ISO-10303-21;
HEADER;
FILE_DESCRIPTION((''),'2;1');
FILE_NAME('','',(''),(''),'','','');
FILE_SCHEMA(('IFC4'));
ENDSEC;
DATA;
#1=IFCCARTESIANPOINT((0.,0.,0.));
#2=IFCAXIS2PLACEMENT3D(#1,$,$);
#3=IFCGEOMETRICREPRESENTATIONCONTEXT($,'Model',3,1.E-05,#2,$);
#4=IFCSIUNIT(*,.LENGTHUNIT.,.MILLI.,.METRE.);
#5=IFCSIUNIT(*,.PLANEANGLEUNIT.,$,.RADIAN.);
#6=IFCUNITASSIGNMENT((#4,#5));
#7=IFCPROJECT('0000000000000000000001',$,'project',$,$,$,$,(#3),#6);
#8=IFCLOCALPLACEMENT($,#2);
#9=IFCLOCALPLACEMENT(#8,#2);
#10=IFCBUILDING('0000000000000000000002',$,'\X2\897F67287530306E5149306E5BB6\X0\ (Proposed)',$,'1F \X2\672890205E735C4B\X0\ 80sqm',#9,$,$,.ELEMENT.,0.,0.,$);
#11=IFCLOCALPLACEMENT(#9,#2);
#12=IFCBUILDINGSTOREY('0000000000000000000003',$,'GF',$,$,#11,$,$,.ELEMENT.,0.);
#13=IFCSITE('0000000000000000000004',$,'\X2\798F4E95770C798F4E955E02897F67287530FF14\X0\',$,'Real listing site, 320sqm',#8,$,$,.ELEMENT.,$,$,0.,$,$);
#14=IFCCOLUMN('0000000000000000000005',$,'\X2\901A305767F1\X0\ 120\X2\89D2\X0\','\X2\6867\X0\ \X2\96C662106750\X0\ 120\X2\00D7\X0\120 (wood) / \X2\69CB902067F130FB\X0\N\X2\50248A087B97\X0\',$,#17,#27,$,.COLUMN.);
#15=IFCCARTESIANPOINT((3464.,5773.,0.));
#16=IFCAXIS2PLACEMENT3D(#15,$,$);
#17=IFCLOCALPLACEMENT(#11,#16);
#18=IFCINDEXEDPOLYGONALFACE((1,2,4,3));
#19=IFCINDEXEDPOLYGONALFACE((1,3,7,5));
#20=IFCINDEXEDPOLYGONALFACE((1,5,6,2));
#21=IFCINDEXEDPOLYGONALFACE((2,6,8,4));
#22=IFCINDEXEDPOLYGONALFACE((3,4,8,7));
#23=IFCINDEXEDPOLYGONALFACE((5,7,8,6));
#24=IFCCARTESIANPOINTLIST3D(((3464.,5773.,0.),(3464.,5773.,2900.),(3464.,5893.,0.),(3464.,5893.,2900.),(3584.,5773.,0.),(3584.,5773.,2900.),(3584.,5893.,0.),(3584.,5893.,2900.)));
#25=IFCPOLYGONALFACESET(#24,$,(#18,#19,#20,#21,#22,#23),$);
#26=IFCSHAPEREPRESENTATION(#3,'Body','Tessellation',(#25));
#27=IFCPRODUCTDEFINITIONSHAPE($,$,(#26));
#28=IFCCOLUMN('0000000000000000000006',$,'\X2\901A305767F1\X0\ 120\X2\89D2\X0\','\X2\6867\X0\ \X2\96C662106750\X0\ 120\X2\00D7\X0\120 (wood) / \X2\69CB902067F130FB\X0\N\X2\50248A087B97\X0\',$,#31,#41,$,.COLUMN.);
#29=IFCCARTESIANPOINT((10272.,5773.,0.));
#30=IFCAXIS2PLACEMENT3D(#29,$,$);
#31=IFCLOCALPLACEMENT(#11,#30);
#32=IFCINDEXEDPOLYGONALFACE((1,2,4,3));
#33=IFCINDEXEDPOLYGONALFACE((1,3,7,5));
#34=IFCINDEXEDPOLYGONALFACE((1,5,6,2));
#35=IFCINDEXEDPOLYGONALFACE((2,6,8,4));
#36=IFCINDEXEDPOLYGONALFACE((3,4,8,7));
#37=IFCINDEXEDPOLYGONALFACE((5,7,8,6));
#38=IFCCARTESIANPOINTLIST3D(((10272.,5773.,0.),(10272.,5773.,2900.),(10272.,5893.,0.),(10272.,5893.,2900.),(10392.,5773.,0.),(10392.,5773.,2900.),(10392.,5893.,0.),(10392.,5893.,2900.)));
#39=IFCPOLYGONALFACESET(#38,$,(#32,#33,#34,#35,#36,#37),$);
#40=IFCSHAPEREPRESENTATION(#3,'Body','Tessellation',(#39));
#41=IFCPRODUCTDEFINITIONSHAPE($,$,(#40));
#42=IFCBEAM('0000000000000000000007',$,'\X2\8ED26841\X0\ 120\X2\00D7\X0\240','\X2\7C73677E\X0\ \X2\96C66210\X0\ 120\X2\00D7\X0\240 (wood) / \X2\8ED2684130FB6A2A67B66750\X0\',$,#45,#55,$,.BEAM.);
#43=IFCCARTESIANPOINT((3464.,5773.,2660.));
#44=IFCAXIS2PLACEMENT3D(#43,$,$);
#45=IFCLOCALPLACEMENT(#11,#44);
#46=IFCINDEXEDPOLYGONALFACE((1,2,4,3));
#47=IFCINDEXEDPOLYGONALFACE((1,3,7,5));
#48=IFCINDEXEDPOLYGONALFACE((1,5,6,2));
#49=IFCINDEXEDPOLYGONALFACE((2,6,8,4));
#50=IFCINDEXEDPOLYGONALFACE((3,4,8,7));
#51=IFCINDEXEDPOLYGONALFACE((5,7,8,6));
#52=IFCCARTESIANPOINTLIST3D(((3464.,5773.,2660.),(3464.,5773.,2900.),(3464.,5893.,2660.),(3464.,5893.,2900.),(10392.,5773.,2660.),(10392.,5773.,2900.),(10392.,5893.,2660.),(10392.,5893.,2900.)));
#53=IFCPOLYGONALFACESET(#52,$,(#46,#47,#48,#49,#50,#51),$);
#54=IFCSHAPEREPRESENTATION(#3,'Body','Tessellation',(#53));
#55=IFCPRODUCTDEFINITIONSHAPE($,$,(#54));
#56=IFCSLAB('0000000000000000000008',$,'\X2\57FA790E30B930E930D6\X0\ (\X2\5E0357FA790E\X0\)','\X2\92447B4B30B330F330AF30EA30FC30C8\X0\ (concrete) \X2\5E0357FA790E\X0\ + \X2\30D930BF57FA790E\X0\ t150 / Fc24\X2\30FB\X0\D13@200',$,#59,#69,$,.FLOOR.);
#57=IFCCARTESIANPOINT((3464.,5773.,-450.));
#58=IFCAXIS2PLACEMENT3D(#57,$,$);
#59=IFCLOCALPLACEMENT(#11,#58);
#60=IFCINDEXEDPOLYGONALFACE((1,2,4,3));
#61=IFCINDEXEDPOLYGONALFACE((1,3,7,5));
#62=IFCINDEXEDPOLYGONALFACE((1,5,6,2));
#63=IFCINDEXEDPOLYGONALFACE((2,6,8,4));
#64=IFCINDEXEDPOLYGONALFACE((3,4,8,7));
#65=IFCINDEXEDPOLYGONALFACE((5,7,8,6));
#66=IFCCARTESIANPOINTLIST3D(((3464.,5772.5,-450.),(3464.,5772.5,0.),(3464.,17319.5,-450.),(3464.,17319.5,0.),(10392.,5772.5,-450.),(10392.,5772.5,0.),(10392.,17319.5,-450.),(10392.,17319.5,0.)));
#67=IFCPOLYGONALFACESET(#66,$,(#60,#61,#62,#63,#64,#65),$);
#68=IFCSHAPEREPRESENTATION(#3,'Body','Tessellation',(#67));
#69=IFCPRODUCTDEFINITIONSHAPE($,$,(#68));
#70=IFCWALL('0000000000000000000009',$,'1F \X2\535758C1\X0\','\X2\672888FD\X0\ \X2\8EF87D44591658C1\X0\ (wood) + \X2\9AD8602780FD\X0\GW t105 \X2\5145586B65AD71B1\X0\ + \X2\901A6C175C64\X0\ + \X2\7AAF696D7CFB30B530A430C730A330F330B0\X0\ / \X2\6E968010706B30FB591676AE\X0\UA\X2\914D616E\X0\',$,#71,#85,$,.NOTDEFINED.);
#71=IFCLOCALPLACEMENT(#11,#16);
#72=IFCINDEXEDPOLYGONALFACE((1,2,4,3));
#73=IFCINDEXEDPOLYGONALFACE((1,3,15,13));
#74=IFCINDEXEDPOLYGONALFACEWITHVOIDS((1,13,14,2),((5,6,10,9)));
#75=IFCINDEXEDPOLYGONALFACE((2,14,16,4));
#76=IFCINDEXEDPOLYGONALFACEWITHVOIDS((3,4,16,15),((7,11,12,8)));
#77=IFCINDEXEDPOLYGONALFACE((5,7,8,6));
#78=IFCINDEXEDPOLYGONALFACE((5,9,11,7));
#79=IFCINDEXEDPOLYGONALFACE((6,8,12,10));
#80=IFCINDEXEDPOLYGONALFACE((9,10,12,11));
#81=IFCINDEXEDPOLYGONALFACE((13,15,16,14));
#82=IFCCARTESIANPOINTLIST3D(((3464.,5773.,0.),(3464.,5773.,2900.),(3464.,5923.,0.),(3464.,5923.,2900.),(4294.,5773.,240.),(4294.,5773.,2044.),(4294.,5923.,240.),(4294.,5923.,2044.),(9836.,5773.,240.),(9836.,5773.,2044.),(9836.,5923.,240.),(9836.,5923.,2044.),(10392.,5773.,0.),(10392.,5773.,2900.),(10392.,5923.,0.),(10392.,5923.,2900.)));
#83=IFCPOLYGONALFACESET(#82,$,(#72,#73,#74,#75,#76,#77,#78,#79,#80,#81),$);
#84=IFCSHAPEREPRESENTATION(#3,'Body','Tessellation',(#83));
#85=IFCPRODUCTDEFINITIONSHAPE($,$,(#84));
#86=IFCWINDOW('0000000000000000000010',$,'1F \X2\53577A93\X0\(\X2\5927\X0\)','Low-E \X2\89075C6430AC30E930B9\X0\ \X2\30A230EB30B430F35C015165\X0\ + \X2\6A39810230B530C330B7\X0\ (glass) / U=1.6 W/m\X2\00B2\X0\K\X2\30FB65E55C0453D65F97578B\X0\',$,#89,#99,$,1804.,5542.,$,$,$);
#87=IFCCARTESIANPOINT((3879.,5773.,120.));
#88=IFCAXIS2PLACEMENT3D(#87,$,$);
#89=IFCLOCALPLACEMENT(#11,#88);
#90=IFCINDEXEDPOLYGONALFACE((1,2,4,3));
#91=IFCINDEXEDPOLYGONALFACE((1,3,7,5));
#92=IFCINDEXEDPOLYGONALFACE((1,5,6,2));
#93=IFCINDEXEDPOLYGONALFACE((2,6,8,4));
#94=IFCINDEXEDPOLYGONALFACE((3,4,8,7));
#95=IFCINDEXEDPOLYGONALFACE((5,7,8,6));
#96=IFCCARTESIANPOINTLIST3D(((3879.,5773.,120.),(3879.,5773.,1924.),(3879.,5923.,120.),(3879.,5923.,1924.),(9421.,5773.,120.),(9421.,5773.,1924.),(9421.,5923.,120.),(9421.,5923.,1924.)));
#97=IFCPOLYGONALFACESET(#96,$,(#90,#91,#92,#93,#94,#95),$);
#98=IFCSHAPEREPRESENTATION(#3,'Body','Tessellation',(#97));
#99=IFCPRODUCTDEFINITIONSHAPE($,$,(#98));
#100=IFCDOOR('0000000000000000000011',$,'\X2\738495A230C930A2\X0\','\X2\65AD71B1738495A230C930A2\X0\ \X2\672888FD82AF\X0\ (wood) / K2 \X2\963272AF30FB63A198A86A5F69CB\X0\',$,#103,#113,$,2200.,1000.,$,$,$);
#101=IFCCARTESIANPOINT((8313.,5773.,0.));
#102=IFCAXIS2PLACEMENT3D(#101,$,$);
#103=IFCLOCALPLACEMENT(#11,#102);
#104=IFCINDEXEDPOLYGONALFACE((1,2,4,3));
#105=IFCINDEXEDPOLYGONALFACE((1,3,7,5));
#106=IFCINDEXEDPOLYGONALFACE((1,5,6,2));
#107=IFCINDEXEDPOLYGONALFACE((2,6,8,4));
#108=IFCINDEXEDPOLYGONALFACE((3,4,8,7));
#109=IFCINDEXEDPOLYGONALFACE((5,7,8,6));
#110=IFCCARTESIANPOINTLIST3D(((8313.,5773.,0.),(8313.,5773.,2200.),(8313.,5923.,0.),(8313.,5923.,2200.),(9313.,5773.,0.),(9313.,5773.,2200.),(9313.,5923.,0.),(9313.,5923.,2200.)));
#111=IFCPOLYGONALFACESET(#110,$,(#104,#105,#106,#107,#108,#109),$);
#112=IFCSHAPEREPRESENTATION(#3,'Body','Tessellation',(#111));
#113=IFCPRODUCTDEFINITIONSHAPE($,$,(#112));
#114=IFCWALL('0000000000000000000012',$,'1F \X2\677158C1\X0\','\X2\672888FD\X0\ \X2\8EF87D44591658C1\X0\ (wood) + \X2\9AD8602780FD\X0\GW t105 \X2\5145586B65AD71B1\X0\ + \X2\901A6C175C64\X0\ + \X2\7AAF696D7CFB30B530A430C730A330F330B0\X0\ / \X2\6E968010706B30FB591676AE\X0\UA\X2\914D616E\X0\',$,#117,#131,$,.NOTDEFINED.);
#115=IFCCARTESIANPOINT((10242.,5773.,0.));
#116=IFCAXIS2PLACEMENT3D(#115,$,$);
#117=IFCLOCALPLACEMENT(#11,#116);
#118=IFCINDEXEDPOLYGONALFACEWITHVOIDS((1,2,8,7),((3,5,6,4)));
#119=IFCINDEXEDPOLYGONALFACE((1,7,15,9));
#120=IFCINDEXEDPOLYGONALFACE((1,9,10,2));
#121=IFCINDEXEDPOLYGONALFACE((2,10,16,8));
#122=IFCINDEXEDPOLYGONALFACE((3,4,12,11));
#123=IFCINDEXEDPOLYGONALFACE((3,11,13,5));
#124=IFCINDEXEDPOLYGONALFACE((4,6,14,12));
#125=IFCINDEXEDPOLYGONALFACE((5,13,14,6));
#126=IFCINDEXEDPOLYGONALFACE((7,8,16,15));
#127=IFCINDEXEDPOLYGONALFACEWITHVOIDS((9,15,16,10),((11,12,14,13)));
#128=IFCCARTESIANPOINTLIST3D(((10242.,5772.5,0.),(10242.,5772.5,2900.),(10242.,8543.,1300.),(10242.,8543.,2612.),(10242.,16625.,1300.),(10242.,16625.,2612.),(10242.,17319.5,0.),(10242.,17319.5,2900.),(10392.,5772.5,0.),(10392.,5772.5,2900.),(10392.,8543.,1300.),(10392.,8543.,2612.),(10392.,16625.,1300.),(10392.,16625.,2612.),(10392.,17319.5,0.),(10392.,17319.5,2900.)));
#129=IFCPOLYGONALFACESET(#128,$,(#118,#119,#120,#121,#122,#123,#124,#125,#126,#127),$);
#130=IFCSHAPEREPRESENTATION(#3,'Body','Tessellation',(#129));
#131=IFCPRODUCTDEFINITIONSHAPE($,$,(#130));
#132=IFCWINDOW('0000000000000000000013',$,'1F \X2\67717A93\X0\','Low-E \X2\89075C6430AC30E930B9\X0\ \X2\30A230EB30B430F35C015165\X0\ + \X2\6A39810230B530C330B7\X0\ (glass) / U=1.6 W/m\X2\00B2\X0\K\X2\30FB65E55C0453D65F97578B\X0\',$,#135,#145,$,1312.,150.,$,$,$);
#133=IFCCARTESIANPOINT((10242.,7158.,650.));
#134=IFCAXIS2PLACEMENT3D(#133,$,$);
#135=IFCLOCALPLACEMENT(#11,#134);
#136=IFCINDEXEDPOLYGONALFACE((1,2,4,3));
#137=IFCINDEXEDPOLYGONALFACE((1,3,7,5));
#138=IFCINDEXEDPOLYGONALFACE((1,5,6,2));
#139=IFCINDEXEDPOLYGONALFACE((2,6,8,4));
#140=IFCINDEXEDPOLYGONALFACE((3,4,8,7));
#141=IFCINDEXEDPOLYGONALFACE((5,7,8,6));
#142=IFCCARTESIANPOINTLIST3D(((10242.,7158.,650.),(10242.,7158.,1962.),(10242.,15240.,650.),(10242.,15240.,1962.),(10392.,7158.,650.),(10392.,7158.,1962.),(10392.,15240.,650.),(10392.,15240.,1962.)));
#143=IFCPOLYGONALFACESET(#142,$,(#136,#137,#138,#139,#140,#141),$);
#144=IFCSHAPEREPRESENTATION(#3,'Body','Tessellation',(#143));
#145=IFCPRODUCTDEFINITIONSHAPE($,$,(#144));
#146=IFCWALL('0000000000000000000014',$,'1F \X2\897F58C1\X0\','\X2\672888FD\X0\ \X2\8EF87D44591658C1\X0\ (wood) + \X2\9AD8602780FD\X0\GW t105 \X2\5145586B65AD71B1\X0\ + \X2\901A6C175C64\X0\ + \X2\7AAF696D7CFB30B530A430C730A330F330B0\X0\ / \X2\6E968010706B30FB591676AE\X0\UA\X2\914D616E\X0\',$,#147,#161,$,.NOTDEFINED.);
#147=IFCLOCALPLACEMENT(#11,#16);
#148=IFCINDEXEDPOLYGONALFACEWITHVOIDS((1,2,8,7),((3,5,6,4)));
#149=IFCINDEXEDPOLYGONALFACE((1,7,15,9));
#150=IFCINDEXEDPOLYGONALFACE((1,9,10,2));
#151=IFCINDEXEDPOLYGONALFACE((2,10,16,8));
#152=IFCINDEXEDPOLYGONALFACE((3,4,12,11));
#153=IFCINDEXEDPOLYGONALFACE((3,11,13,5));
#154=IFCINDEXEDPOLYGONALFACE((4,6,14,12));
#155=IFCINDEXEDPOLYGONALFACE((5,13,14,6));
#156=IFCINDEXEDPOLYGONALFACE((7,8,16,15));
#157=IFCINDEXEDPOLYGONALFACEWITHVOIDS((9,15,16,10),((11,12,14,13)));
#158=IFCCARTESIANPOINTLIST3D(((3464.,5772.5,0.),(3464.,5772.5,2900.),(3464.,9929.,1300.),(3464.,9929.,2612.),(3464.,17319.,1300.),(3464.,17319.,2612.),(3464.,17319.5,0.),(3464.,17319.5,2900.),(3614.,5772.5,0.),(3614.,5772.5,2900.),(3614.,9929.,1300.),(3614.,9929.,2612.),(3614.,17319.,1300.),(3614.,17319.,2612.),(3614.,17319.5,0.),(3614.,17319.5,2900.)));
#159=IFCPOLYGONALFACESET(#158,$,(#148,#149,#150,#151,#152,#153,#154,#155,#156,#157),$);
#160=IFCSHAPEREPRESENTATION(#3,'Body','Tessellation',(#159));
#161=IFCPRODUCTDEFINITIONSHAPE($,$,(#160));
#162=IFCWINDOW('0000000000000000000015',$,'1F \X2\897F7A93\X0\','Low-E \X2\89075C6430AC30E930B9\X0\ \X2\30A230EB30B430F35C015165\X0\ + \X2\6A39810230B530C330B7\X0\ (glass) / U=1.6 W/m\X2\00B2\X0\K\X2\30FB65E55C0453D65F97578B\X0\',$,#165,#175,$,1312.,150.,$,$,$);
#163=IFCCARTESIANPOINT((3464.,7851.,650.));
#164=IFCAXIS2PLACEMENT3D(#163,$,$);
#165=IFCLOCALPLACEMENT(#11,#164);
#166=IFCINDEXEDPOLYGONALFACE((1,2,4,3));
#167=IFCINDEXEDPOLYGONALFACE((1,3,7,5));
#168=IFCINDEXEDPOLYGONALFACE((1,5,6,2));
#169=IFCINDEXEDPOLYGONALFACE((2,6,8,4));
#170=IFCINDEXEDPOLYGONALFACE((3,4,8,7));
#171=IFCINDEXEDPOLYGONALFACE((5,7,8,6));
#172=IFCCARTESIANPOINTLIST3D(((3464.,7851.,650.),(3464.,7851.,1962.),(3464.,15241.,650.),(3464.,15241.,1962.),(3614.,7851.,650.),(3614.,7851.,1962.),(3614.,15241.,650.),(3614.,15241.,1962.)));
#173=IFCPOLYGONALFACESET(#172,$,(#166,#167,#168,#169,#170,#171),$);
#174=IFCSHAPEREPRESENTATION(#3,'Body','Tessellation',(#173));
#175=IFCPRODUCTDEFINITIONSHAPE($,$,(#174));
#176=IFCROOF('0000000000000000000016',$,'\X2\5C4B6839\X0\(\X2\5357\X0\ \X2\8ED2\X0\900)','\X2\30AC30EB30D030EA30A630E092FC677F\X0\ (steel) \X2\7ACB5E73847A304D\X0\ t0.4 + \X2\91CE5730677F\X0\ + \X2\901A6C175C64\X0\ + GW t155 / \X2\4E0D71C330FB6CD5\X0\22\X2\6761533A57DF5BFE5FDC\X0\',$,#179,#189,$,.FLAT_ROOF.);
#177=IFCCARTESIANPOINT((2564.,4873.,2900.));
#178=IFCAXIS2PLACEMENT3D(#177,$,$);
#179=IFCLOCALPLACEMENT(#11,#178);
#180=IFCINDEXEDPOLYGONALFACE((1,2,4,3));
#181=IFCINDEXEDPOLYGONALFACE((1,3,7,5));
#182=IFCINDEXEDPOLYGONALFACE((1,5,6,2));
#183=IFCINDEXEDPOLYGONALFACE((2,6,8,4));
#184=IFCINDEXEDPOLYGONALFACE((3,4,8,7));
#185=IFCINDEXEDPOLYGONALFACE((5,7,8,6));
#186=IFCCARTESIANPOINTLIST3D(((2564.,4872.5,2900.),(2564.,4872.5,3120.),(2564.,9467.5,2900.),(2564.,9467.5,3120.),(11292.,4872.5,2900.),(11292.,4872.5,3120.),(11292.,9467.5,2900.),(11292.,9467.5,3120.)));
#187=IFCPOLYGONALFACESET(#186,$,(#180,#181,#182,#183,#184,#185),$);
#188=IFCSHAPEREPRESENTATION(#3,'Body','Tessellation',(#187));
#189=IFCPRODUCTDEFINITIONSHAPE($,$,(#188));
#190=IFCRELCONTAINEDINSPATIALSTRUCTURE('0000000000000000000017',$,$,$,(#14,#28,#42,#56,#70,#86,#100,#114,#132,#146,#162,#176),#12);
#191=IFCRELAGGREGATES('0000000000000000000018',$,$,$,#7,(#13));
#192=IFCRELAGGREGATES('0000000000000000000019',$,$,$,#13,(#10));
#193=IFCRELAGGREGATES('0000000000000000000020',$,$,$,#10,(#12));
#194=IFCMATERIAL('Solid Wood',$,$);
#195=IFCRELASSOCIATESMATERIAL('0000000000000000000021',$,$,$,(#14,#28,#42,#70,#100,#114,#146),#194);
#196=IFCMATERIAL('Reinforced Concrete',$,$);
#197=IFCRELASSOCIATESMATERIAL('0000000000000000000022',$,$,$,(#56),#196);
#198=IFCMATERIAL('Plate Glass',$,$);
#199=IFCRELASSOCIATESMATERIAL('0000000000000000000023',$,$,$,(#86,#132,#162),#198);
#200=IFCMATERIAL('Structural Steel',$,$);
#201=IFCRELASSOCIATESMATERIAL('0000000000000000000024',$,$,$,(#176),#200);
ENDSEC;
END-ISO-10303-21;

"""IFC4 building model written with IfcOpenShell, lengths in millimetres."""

from ifc_helpers import new_model, si_unit, frame, frame_2d, origin, place, context, project, spatial, rectangle, extrude, material, element, fill, save


model = new_model("IFC4")

# Units and contexts
model_context = context("Model", 3, precision=1e-05, world=origin())
ifc_project = project(units=[si_unit("LENGTHUNIT", "METRE", prefix="MILLI"), si_unit("PLANEANGLEUNIT", "RADIAN")], contexts=[model_context])

# Site, building, storey
site_placement = place(None, origin())
site = spatial("IfcSite", under=ifc_project, at=site_placement, Name="福井県福井市西木田４", ObjectType="Real listing site, 320sqm", CompositionType="ELEMENT", RefElevation=0.0)
building_placement = place(site_placement, origin())
building = spatial("IfcBuilding", under=site, at=building_placement, Name="西木田の光の家 (Proposed)", ObjectType="1F 木造平屋 80sqm", CompositionType="ELEMENT", ElevationOfRefHeight=0.0, ElevationOfTerrain=0.0)
storey_placement = place(building_placement, origin())
storey = spatial("IfcBuildingStorey", under=building, at=storey_placement, Name="GF", CompositionType="ELEMENT", Elevation=0.0)

# Columns
ifc_material_1 = material(Name="Solid Wood")
column_1_placement = place(storey_placement, frame((3464.0, 5773.0, 0.0)))
element("IfcColumn", 1, at=column_1_placement, inside=storey, material=ifc_material_1, Name="通し柱 120角", Description="桧 集成材 120×120 (wood) / 構造柱・N値計算", PredefinedType="COLUMN", context=model_context, shape_type="SweptSolid", body=[
    extrude(rectangle(XDim=120.0, YDim=120.0, at=frame_2d((60.0, 60.0))), frame((3464.0, 5773.0, 0.0)), (0.0, 0.0, 1.0), 2900.0),
])
column_2_placement = place(storey_placement, frame((10272.0, 5773.0, 0.0)))
element("IfcColumn", 2, at=column_2_placement, inside=storey, material=ifc_material_1, Name="通し柱 120角", Description="桧 集成材 120×120 (wood) / 構造柱・N値計算", PredefinedType="COLUMN", context=model_context, shape_type="SweptSolid", body=[
    extrude(rectangle(XDim=120.0, YDim=120.0, at=frame_2d((60.0, 60.0))), frame((10272.0, 5773.0, 0.0)), (0.0, 0.0, 1.0), 2900.0),
])

# Beam
beam_1_placement = place(storey_placement, frame((3464.0, 5773.0, 2660.0)))
element("IfcBeam", 3, at=beam_1_placement, inside=storey, material=ifc_material_1, Name="軒桁 120×240", Description="米松 集成 120×240 (wood) / 軒桁・横架材", PredefinedType="BEAM", context=model_context, shape_type="SweptSolid", body=[
    extrude(rectangle(XDim=6928.0, YDim=120.0, at=frame_2d((3464.0, 60.0))), frame((3464.0, 5773.0, 2660.0)), (0.0, 0.0, 1.0), 240.0),
])

# Slab
ifc_material_2 = material(Name="Reinforced Concrete")
slab_1_placement = place(storey_placement, frame((3464.0, 5773.0, -450.0)))
element("IfcSlab", 4, at=slab_1_placement, inside=storey, material=ifc_material_2, Name="基礎スラブ (布基礎)", Description="鉄筋コンクリート (concrete) 布基礎 + ベタ基礎 t150 / Fc24・D13@200", PredefinedType="FLOOR", context=model_context, shape_type="SweptSolid", body=[
    extrude(rectangle(XDim=6928.0, YDim=11547.0, at=frame_2d((3464.0, 5773.0))), frame((3464.0, 5773.0, -450.0)), (0.0, 0.0, 1.0), 450.0),
])

# Wall, openings, window, door
wall_1_placement = place(storey_placement, frame((3464.0, 5773.0, 0.0)))
wall_1 = element("IfcWall", 5, at=wall_1_placement, inside=storey, material=ifc_material_1, Name="1F 南壁", Description="木製 軸組外壁 (wood) + 高性能GW t105 充填断熱 + 通気層 + 窯業系サイディング / 準耐火・外皮UA配慮", PredefinedType="NOTDEFINED", context=model_context, shape_type="SweptSolid", body=[
    extrude(rectangle(XDim=6928.0, YDim=150.0, at=frame_2d((3464.0, 75.0))), frame((3464.0, 5773.0, 0.0)), (0.0, 0.0, 1.0), 2900.0),
])
opening_1_placement = place(storey_placement, frame((3879.0, 5773.0, 120.0)))
opening_1 = element("IfcOpeningElement", 6, at=opening_1_placement, cuts=wall_1, PredefinedType="NOTDEFINED", context=model_context, shape_type="SweptSolid", body=[
    extrude(rectangle(XDim=5542.0, YDim=150.0, at=frame_2d((2771.0, 75.0))), frame((3879.0, 5773.0, 120.0)), (0.0, 0.0, 1.0), 1804.0),
])
opening_2_placement = place(storey_placement, frame((8313.0, 5773.0, 0.0)))
opening_2 = element("IfcOpeningElement", 7, at=opening_2_placement, cuts=wall_1, PredefinedType="NOTDEFINED", context=model_context, shape_type="SweptSolid", body=[
    extrude(rectangle(XDim=1000.0, YDim=150.0, at=frame_2d((500.0, 75.0))), frame((8313.0, 5773.0, 0.0)), (0.0, 0.0, 1.0), 2200.0),
])
ifc_material_3 = material(Name="Plate Glass")
window_1_placement = place(storey_placement, frame((3879.0, 5773.0, 120.0)))
window_1 = element("IfcWindow", 8, at=window_1_placement, inside=storey, material=ifc_material_3, Name="1F 南窓(大)", Description="Low-E 複層ガラス アルゴン封入 + 樹脂サッシ (glass) / U=1.6 W/m²K・日射取得型", OverallHeight=1804.0, OverallWidth=5542.0, context=model_context, shape_type="SweptSolid", body=[
    extrude(rectangle(XDim=5542.0, YDim=150.0, at=frame_2d((2771.0, 75.0))), frame((3879.0, 5773.0, 120.0)), (0.0, 0.0, 1.0), 1804.0),
])
fill(opening_1, window_1)
door_placement = place(storey_placement, frame((8313.0, 5773.0, 0.0)))
door = element("IfcDoor", 9, at=door_placement, inside=storey, material=ifc_material_1, Name="玄関ドア", Description="断熱玄関ドア 木製芯 (wood) / K2 防犯・採風機構", OverallHeight=2200.0, OverallWidth=1000.0, context=model_context, shape_type="SweptSolid", body=[
    extrude(rectangle(XDim=1000.0, YDim=150.0, at=frame_2d((500.0, 75.0))), frame((8313.0, 5773.0, 0.0)), (0.0, 0.0, 1.0), 2200.0),
])
fill(opening_2, door)

# Walls, openings, windows
wall_2_placement = place(storey_placement, frame((10242.0, 5773.0, 0.0)))
wall_2 = element("IfcWall", 10, at=wall_2_placement, inside=storey, material=ifc_material_1, Name="1F 東壁", Description="木製 軸組外壁 (wood) + 高性能GW t105 充填断熱 + 通気層 + 窯業系サイディング / 準耐火・外皮UA配慮", PredefinedType="NOTDEFINED", context=model_context, shape_type="SweptSolid", body=[
    extrude(rectangle(XDim=150.0, YDim=11547.0, at=frame_2d((75.0, 5773.0))), frame((10242.0, 5773.0, 0.0)), (0.0, 0.0, 1.0), 2900.0),
])
opening_3_placement = place(storey_placement, frame((10242.0, 7158.0, 650.0)))
opening_3 = element("IfcOpeningElement", 11, at=opening_3_placement, cuts=wall_2, PredefinedType="NOTDEFINED", context=model_context, shape_type="SweptSolid", body=[
    extrude(rectangle(XDim=150.0, YDim=8082.0, at=frame_2d((75.0, 4041.0))), frame((10242.0, 7158.0, 650.0)), (0.0, 0.0, 1.0), 1312.0),
])
window_2_placement = place(storey_placement, frame((10242.0, 7158.0, 650.0)))
window_2 = element("IfcWindow", 12, at=window_2_placement, inside=storey, material=ifc_material_3, Name="1F 東窓", Description="Low-E 複層ガラス アルゴン封入 + 樹脂サッシ (glass) / U=1.6 W/m²K・日射取得型", OverallHeight=1312.0, OverallWidth=150.0, context=model_context, shape_type="SweptSolid", body=[
    extrude(rectangle(XDim=150.0, YDim=8082.0, at=frame_2d((75.0, 4041.0))), frame((10242.0, 7158.0, 650.0)), (0.0, 0.0, 1.0), 1312.0),
])
fill(opening_3, window_2)
wall_3_placement = place(storey_placement, frame((3464.0, 5773.0, 0.0)))
wall_3 = element("IfcWall", 13, at=wall_3_placement, inside=storey, material=ifc_material_1, Name="1F 西壁", Description="木製 軸組外壁 (wood) + 高性能GW t105 充填断熱 + 通気層 + 窯業系サイディング / 準耐火・外皮UA配慮", PredefinedType="NOTDEFINED", context=model_context, shape_type="SweptSolid", body=[
    extrude(rectangle(XDim=150.0, YDim=11547.0, at=frame_2d((75.0, 5773.0))), frame((3464.0, 5773.0, 0.0)), (0.0, 0.0, 1.0), 2900.0),
])
opening_4_placement = place(storey_placement, frame((3464.0, 7851.0, 650.0)))
opening_4 = element("IfcOpeningElement", 14, at=opening_4_placement, cuts=wall_3, PredefinedType="NOTDEFINED", context=model_context, shape_type="SweptSolid", body=[
    extrude(rectangle(XDim=150.0, YDim=7390.0, at=frame_2d((75.0, 3695.0))), frame((3464.0, 7851.0, 650.0)), (0.0, 0.0, 1.0), 1312.0),
])
window_3_placement = place(storey_placement, frame((3464.0, 7851.0, 650.0)))
window_3 = element("IfcWindow", 15, at=window_3_placement, inside=storey, material=ifc_material_3, Name="1F 西窓", Description="Low-E 複層ガラス アルゴン封入 + 樹脂サッシ (glass) / U=1.6 W/m²K・日射取得型", OverallHeight=1312.0, OverallWidth=150.0, context=model_context, shape_type="SweptSolid", body=[
    extrude(rectangle(XDim=150.0, YDim=7390.0, at=frame_2d((75.0, 3695.0))), frame((3464.0, 7851.0, 650.0)), (0.0, 0.0, 1.0), 1312.0),
])
fill(opening_4, window_3)

# Roof
ifc_material_4 = material(Name="Structural Steel")
roof_placement = place(storey_placement, frame((2564.0, 4873.0, 2900.0)))
element("IfcRoof", 16, at=roof_placement, inside=storey, material=ifc_material_4, Name="屋根(南 軒900)", Description="ガルバリウム鋼板 (steel) 立平葺き t0.4 + 野地板 + 通気層 + GW t155 / 不燃・法22条区域対応", PredefinedType="FLAT_ROOF", context=model_context, shape_type="SweptSolid", body=[
    extrude(rectangle(XDim=8728.0, YDim=4595.0, at=frame_2d((4364.0, 2297.0))), frame((2564.0, 4873.0, 2900.0)), (0.0, 0.0, 1.0), 220.0),
])

save(model, "model.ifc")
